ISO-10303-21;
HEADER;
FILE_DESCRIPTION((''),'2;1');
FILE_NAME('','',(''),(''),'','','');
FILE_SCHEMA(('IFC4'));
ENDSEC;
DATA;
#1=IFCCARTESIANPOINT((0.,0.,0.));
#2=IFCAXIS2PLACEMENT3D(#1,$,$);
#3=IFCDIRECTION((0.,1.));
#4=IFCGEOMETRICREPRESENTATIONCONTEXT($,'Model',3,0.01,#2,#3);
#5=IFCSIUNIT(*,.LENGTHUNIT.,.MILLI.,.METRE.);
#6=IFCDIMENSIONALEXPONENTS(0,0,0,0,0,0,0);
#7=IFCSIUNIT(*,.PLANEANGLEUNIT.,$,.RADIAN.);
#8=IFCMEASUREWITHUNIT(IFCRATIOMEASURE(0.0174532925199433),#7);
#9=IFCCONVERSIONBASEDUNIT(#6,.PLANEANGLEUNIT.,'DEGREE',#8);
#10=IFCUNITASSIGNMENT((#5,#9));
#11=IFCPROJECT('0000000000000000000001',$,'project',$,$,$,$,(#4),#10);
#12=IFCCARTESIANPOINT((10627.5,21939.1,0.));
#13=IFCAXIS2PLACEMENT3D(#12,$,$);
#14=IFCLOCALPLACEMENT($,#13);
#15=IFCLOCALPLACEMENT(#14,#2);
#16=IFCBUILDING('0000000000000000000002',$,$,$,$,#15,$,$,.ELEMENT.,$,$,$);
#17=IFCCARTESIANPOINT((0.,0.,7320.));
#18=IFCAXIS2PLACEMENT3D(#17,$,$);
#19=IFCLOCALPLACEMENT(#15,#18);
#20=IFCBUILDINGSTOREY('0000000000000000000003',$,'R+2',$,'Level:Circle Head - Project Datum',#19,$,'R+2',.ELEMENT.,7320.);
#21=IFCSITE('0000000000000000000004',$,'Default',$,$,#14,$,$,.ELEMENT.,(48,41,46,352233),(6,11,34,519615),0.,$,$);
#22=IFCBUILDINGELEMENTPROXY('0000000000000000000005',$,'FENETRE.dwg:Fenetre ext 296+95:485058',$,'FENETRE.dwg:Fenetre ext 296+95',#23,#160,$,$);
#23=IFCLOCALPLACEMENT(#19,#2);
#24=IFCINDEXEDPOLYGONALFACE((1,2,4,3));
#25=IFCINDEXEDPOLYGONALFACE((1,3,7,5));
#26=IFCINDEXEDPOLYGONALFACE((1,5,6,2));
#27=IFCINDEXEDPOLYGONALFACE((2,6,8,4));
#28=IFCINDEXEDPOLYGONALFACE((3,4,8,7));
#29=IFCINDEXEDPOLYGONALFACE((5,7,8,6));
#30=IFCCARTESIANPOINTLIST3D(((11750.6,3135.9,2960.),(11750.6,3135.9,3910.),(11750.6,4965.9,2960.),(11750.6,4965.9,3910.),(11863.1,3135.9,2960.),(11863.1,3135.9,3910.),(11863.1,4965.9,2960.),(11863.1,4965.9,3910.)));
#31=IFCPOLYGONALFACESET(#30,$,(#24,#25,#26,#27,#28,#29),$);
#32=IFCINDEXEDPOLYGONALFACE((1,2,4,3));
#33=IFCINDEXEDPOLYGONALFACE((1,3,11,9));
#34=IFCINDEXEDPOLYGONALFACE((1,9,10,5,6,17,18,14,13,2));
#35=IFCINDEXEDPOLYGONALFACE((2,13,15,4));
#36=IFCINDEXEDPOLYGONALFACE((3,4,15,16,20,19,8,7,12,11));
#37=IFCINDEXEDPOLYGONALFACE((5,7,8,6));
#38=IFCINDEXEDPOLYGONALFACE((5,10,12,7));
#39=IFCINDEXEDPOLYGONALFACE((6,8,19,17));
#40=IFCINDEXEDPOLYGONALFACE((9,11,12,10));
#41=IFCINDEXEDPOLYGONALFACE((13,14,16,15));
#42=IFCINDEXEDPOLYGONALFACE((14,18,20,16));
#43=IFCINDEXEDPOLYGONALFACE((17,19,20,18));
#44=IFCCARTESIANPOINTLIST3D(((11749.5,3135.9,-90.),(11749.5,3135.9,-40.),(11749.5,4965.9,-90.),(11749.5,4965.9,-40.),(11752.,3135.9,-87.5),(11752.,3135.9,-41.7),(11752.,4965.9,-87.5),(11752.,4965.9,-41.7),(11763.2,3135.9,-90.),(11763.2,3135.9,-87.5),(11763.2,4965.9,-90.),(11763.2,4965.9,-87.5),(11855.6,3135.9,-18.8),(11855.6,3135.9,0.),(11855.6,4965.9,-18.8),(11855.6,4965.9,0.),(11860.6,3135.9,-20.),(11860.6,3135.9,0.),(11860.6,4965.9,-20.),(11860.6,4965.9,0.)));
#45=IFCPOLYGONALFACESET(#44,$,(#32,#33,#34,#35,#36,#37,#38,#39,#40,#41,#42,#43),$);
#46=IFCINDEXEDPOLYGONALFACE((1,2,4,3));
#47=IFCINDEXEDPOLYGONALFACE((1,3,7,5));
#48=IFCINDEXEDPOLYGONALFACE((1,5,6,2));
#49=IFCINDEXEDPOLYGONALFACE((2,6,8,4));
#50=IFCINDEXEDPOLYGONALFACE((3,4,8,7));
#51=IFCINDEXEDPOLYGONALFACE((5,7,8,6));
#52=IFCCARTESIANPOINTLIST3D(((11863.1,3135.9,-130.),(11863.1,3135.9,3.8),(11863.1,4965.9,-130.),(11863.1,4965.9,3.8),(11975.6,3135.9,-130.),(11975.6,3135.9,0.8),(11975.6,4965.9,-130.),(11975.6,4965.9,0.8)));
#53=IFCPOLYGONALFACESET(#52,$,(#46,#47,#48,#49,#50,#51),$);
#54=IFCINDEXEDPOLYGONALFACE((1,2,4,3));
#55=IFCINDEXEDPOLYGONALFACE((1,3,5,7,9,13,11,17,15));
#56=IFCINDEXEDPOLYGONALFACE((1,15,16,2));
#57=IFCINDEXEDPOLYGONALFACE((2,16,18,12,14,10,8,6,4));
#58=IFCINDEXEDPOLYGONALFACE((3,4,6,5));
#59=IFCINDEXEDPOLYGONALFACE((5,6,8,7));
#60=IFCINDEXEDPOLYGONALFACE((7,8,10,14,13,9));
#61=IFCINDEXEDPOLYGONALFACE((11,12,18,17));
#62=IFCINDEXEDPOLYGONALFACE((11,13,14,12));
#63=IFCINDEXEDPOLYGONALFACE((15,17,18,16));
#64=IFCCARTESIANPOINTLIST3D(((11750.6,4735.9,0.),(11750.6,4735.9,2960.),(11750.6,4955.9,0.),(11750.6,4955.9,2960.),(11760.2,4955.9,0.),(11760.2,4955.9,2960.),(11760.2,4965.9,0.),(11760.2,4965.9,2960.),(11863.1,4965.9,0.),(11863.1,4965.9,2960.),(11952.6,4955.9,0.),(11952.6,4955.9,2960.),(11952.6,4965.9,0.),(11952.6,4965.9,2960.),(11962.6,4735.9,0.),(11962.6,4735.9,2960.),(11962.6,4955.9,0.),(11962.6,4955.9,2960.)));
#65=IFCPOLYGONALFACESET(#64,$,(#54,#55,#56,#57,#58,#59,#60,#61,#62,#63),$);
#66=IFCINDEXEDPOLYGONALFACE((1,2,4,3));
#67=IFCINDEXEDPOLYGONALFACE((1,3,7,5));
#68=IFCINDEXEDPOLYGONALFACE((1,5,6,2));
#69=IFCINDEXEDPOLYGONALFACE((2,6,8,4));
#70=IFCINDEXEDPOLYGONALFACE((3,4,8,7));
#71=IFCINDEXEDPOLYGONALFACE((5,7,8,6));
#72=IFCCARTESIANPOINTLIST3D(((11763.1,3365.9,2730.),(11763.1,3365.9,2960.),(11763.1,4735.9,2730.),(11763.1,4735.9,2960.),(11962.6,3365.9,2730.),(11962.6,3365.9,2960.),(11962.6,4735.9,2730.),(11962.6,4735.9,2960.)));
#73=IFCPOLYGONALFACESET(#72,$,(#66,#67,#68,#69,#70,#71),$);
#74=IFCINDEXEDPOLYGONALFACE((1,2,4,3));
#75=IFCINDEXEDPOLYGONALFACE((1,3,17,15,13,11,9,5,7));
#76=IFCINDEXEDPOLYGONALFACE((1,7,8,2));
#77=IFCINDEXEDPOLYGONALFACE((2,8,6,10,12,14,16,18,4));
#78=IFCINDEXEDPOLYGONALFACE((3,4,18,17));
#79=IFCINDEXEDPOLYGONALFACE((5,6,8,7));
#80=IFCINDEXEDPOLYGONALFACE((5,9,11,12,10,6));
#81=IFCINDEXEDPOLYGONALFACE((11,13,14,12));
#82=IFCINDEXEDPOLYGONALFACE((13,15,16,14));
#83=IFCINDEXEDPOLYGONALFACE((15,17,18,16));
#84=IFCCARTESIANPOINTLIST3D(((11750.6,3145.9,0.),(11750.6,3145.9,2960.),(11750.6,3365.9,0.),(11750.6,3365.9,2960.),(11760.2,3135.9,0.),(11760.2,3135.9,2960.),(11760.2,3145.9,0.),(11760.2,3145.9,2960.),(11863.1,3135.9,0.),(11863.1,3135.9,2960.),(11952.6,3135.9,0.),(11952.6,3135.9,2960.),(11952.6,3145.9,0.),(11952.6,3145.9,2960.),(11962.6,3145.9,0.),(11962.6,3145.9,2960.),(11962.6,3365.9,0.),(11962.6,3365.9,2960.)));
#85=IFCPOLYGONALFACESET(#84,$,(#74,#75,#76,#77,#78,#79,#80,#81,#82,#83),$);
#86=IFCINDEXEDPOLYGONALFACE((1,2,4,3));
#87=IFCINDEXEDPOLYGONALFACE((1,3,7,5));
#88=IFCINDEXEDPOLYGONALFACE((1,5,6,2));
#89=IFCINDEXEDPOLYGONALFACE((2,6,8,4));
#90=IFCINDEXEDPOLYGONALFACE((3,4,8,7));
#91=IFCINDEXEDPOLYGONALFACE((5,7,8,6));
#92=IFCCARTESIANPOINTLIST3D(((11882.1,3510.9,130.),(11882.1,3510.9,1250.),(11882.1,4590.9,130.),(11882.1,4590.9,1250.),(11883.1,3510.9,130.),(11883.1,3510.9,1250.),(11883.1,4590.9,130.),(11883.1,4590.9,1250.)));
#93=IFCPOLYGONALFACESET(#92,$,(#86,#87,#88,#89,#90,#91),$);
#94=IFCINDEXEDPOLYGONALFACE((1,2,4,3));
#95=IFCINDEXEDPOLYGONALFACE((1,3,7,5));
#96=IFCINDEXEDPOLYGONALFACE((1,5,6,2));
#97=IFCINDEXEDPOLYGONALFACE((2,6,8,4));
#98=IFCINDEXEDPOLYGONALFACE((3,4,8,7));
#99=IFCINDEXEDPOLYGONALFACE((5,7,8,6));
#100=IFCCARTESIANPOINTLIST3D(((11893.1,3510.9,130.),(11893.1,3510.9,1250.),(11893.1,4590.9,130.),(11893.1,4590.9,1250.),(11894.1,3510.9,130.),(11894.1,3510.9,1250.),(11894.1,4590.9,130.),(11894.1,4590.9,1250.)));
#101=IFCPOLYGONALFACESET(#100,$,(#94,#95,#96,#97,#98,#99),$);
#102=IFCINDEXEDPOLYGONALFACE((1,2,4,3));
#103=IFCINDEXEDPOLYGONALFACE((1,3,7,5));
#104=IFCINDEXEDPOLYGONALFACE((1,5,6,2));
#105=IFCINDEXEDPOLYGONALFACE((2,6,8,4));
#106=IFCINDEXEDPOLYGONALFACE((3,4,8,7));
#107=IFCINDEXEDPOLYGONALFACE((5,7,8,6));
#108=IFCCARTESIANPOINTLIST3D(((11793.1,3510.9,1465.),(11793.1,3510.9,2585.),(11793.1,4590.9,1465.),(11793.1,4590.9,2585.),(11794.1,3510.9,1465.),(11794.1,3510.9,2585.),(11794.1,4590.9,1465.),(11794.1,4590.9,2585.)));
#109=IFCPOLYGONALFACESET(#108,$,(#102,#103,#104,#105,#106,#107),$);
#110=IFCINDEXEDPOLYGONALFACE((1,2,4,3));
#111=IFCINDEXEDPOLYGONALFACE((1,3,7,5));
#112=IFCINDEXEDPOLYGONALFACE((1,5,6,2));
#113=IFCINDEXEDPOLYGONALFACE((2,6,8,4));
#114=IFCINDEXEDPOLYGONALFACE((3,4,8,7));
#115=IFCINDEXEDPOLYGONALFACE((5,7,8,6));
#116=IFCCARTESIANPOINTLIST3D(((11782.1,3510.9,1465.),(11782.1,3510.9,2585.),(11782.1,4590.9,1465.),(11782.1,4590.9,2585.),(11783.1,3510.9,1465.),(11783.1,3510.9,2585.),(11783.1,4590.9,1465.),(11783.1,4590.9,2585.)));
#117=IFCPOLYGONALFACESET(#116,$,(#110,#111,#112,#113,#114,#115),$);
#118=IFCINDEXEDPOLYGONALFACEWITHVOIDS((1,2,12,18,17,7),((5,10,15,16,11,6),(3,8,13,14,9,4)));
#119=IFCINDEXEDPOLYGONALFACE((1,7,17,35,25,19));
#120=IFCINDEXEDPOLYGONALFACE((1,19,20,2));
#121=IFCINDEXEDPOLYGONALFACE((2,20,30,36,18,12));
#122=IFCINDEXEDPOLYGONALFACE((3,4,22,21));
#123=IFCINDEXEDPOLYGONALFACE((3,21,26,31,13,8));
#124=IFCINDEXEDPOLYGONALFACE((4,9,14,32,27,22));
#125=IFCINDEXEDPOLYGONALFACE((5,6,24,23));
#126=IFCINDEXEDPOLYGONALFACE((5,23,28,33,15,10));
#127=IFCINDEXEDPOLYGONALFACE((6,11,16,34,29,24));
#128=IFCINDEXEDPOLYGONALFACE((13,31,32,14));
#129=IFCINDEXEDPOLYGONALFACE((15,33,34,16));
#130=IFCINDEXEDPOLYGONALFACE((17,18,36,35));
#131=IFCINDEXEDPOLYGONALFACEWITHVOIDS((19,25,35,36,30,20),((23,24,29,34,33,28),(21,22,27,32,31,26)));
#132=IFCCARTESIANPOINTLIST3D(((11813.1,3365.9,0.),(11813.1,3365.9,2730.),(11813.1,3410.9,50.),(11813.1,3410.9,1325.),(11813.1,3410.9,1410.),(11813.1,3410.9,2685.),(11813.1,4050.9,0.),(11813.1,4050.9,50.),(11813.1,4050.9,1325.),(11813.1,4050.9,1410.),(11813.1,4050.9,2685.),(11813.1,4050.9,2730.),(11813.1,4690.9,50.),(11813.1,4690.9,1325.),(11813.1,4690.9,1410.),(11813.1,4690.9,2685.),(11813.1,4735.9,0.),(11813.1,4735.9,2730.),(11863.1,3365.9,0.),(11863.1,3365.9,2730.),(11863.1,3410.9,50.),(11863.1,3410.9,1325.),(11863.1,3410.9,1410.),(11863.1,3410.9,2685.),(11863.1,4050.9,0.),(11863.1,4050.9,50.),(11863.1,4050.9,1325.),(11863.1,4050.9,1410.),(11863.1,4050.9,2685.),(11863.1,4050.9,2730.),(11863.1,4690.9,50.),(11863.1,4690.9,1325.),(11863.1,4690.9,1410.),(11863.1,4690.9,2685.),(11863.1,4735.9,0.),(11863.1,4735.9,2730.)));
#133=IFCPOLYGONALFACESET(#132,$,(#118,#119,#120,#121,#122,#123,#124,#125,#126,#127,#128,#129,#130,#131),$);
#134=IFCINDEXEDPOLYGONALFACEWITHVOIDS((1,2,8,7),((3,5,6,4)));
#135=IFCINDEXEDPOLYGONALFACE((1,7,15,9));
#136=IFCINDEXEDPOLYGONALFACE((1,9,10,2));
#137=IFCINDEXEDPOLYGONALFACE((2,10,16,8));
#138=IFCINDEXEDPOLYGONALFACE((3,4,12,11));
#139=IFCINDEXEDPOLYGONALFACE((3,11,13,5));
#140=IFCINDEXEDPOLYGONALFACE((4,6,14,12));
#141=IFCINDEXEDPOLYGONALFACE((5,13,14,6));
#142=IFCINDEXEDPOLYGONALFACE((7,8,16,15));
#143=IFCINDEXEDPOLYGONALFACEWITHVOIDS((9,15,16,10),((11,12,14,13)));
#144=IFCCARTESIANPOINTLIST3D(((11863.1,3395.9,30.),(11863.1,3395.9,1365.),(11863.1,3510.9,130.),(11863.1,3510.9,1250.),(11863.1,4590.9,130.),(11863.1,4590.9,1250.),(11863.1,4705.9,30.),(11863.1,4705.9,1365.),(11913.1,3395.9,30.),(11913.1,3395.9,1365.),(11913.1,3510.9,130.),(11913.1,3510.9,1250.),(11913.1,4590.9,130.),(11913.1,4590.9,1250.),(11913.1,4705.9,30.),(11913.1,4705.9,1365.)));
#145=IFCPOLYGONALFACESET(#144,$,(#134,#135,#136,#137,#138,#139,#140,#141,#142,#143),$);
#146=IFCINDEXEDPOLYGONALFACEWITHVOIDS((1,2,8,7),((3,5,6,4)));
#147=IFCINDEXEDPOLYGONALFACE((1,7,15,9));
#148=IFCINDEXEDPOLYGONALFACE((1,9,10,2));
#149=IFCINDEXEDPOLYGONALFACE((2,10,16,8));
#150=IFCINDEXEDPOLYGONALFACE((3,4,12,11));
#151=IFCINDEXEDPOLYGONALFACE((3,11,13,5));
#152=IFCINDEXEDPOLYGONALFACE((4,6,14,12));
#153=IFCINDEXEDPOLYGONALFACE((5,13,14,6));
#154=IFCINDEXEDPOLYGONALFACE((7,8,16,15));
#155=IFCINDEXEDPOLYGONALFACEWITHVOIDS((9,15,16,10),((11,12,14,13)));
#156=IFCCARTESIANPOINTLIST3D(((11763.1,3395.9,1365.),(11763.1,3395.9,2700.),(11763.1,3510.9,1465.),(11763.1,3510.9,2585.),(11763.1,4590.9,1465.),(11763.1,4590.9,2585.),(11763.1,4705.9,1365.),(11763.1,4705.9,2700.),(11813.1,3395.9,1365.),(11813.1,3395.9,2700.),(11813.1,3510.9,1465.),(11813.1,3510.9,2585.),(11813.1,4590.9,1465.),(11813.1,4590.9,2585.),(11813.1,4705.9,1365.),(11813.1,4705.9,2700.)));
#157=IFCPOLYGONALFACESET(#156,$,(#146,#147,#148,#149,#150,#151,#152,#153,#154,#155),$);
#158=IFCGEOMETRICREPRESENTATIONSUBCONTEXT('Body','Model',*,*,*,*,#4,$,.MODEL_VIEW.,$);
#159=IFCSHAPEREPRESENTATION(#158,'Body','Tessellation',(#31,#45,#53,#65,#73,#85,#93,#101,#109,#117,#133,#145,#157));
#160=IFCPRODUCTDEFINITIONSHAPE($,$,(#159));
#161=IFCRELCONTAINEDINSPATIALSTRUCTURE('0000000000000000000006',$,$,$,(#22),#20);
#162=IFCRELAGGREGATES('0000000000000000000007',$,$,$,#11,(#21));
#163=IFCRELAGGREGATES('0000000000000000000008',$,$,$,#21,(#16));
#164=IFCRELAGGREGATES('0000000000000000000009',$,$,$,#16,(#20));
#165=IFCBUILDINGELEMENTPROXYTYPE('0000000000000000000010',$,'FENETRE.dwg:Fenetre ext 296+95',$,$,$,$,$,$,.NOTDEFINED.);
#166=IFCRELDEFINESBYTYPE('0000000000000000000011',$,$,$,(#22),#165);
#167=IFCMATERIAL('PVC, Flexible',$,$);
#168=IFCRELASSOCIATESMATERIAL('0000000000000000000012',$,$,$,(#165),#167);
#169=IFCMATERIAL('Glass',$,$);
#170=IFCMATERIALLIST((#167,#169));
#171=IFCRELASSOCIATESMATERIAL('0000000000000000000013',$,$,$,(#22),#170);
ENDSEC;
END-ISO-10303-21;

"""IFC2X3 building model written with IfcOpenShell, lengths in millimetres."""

from ifc_helpers import new_model, entity, si_unit, converted_unit, direction, frame, frame_2d, origin, origin_2d_with_axis, place, context, subcontext, project, spatial, polyline, rectangle, outline, extrude, source, transform, mapped, material, material_list, type_object, type_shapes, element, save


model = new_model("IFC2X3")

# Units and contexts
model_context = context("Model", 3, precision=0.01, world=origin(), true_north=direction((0.0, 1.0)))
body_context = subcontext(model_context, "Body", "Model", "MODEL_VIEW")
ifc_project = project(units=[si_unit("LENGTHUNIT", "METRE", prefix="MILLI"), converted_unit("PLANEANGLEUNIT", "DEGREE", entity("IfcRatioMeasure", 0.0174532925199433), si_unit("PLANEANGLEUNIT", "RADIAN"), dimensions=[0, 0, 0, 0, 0, 0, 0])], contexts=[model_context])

# Site, building, storey
site_placement = place(None, frame((10627.5, 21939.1, 0.0)))
site = spatial("IfcSite", under=ifc_project, at=site_placement, Name="Default", CompositionType="ELEMENT", RefLatitude=(48, 41, 46, 352233), RefLongitude=(6, 11, 34, 519615), RefElevation=0.0)
building_placement = place(site_placement, origin())
building = spatial("IfcBuilding", under=site, at=building_placement, CompositionType="ELEMENT")
storey_placement = place(building_placement, frame((0.0, 0.0, 7320.0)))
storey = spatial("IfcBuildingStorey", under=building, at=storey_placement, Name="R+2", ObjectType="Level:Circle Head - Project Datum", LongName="R+2", CompositionType="ELEMENT", Elevation=7320.0)

# Building element proxy
ifc_material_1 = material(Name="PVC, Flexible")
ifc_material_2 = material(Name="Glass")
building_element_proxy_type_1 = type_object("IfcBuildingElementProxyType", Name="FENETRE.dwg:Fenetre ext 296+95", PredefinedType="NOTDEFINED", material=ifc_material_1)
shared_shape_1 = source(origin(), body_context, "Body", "SweptSolid", [
    extrude(rectangle(XDim=1830.0, YDim=112.5, at=origin_2d_with_axis()), frame((-10.4, 56.3, 2960.0), z_axis=(0.0, 0.0, 1.0), x_axis=(-1.0, 0.0, 0.0)), (0.0, 0.0, 1.0), 950.0),
    extrude(outline(polyline([(-68.6, -14.4), (-72.5, -34.0), (-67.6, -35.0), (-63.9, -16.6), (44.3, -16.6), (54.1, 32.5), (40.6, 35.2), (40.1, 32.7), (51.2, 30.5), (42.2, -14.4), (-68.6, -14.4)])), frame((-925.4, 66.9, -47.5), z_axis=(-1.0, 0.0, 0.0), x_axis=(0.0, 0.980599, -0.196027)), (0.0, 0.0, -1.0), 1830.0),
    extrude(outline(polyline([(-64.7, -56.3), (66.2, -56.3), (66.2, 56.3), (-67.7, 56.3), (-64.7, -56.3)])), frame((-925.4, -56.3, -63.8), z_axis=(1.0, 0.0, 0.0), x_axis=(0.0, 0.0, -1.0)), (0.0, 0.0, 1.0), 1830.0),
    extrude(outline(polyline([(-55.6, 97.0), (-55.6, -5.9), (-55.6, -95.4), (-45.6, -95.4), (-45.6, -105.4), (174.4, -105.4), (174.4, 106.6), (-45.6, 106.6), (-45.6, 97.0), (-55.6, 97.0)])), frame((849.0, 5.9, 0.0), z_axis=(0.0, 0.0, -1.0), x_axis=(-1.0, 0.0, 0.0)), (0.0, 0.0, -1.0), 2960.0),
    extrude(rectangle(XDim=199.5, YDim=1370.0, at=origin_2d_with_axis()), frame((-10.4, 0.3, 2730.0), z_axis=(0.0, 0.0, 1.0), x_axis=(0.0, 1.0, 0.0)), (0.0, 0.0, 1.0), 230.0),
    extrude(outline(polyline([(-97.0, -55.6), (5.9, -55.6), (95.4, -55.6), (95.4, -45.6), (105.4, -45.6), (105.4, 174.4), (-106.6, 174.4), (-106.6, -45.6), (-97.0, -45.6), (-97.0, -55.6)])), frame((-869.9, 5.9, 0.0), z_axis=(0.0, 0.0, 1.0), x_axis=(0.0, -1.0, 0.0)), (0.0, 0.0, 1.0), 2960.0),
    extrude(rectangle(XDim=1.0, YDim=1080.0, at=origin_2d_with_axis()), frame((-10.4, -19.5, 130.0), z_axis=(0.0, 0.0, 1.0), x_axis=(0.0, 1.0, 0.0)), (0.0, 0.0, 1.0), 1120.0),
    extrude(rectangle(XDim=1.0, YDim=1080.0, at=frame_2d((0.0, 0.0), x_axis=(1.0, 0.0))), frame((-10.4, -30.5, 130.0), z_axis=(0.0, 0.0, 1.0), x_axis=(0.0, 1.0, 0.0)), (0.0, 0.0, 1.0), 1120.0),
    extrude(rectangle(XDim=1.0, YDim=1080.0, at=frame_2d((0.0, 0.0), x_axis=(1.0, 0.0))), frame((-10.4, 69.5, 1465.0), z_axis=(0.0, 0.0, 1.0), x_axis=(0.0, 1.0, 0.0)), (0.0, 0.0, 1.0), 1120.0),
    extrude(rectangle(XDim=1.0, YDim=1080.0, at=frame_2d((0.0, 0.0), x_axis=(1.0, 0.0))), frame((-10.4, 80.5, 1465.0), z_axis=(0.0, 0.0, 1.0), x_axis=(0.0, 1.0, 0.0)), (0.0, 0.0, 1.0), 1120.0),
    extrude(outline(polyline([(-685.0, -1365.0), (0.0, -1365.0), (685.0, -1365.0), (685.0, 1365.0), (0.0, 1365.0), (-685.0, 1365.0), (-685.0, -1365.0)]), holes=[polyline([(-640.0, -1320.0), (-640.0, -45.0), (0.0, -45.0), (640.0, -45.0), (640.0, -1320.0), (0.0, -1320.0), (-640.0, -1320.0)]), polyline([(-640.0, 40.0), (-640.0, 1315.0), (0.0, 1315.0), (640.0, 1315.0), (640.0, 40.0), (0.0, 40.0), (-640.0, 40.0)])]), frame((-10.4, 0.0, 1365.0), z_axis=(0.0, 1.0, 0.0), x_axis=(1.0, 0.0, 0.0)), (0.0, 0.0, 1.0), 50.0),
    extrude(outline(polyline([(-655.0, -667.5), (655.0, -667.5), (655.0, 667.5), (-655.0, 667.5), (-655.0, -667.5)]), holes=[polyline([(-540.0, 552.5), (540.0, 552.5), (540.0, -567.5), (-540.0, -567.5), (-540.0, 552.5)])]), frame((-10.4, -50.0, 697.5), z_axis=(0.0, 1.0, 0.0), x_axis=(-1.0, 0.0, 0.0)), (0.0, 0.0, 1.0), 50.0),
    extrude(outline(polyline([(-655.0, -667.5), (655.0, -667.5), (655.0, 667.5), (-655.0, 667.5), (-655.0, -667.5)]), holes=[polyline([(-540.0, 552.5), (540.0, 552.5), (540.0, -567.5), (-540.0, -567.5), (-540.0, 552.5)])]), frame((-10.4, 50.0, 2032.5), z_axis=(0.0, 1.0, 0.0), x_axis=(-1.0, 0.0, 0.0)), (0.0, 0.0, 1.0), 50.0),
])
type_shapes(building_element_proxy_type_1, [shared_shape_1])
ifc_material_list_1 = material_list([ifc_material_1, ifc_material_2])
proxy_1_placement = place(storey_placement, frame((11863.1, 4061.3, 0.0), z_axis=(0.0, 0.0, 1.0), x_axis=(0.0, 1.0, 0.0)))
element("IfcBuildingElementProxy", 1, at=proxy_1_placement, inside=storey, type_object=building_element_proxy_type_1, material=ifc_material_list_1, Name="FENETRE.dwg:Fenetre ext 296+95:485058", ObjectType="FENETRE.dwg:Fenetre ext 296+95", context=body_context, shape_type="MappedRepresentation", body=[
    mapped(shared_shape_1, transform((0.0, 0.0, 0.0), scale=1.0)),
])

save(model, "model.ifc")
